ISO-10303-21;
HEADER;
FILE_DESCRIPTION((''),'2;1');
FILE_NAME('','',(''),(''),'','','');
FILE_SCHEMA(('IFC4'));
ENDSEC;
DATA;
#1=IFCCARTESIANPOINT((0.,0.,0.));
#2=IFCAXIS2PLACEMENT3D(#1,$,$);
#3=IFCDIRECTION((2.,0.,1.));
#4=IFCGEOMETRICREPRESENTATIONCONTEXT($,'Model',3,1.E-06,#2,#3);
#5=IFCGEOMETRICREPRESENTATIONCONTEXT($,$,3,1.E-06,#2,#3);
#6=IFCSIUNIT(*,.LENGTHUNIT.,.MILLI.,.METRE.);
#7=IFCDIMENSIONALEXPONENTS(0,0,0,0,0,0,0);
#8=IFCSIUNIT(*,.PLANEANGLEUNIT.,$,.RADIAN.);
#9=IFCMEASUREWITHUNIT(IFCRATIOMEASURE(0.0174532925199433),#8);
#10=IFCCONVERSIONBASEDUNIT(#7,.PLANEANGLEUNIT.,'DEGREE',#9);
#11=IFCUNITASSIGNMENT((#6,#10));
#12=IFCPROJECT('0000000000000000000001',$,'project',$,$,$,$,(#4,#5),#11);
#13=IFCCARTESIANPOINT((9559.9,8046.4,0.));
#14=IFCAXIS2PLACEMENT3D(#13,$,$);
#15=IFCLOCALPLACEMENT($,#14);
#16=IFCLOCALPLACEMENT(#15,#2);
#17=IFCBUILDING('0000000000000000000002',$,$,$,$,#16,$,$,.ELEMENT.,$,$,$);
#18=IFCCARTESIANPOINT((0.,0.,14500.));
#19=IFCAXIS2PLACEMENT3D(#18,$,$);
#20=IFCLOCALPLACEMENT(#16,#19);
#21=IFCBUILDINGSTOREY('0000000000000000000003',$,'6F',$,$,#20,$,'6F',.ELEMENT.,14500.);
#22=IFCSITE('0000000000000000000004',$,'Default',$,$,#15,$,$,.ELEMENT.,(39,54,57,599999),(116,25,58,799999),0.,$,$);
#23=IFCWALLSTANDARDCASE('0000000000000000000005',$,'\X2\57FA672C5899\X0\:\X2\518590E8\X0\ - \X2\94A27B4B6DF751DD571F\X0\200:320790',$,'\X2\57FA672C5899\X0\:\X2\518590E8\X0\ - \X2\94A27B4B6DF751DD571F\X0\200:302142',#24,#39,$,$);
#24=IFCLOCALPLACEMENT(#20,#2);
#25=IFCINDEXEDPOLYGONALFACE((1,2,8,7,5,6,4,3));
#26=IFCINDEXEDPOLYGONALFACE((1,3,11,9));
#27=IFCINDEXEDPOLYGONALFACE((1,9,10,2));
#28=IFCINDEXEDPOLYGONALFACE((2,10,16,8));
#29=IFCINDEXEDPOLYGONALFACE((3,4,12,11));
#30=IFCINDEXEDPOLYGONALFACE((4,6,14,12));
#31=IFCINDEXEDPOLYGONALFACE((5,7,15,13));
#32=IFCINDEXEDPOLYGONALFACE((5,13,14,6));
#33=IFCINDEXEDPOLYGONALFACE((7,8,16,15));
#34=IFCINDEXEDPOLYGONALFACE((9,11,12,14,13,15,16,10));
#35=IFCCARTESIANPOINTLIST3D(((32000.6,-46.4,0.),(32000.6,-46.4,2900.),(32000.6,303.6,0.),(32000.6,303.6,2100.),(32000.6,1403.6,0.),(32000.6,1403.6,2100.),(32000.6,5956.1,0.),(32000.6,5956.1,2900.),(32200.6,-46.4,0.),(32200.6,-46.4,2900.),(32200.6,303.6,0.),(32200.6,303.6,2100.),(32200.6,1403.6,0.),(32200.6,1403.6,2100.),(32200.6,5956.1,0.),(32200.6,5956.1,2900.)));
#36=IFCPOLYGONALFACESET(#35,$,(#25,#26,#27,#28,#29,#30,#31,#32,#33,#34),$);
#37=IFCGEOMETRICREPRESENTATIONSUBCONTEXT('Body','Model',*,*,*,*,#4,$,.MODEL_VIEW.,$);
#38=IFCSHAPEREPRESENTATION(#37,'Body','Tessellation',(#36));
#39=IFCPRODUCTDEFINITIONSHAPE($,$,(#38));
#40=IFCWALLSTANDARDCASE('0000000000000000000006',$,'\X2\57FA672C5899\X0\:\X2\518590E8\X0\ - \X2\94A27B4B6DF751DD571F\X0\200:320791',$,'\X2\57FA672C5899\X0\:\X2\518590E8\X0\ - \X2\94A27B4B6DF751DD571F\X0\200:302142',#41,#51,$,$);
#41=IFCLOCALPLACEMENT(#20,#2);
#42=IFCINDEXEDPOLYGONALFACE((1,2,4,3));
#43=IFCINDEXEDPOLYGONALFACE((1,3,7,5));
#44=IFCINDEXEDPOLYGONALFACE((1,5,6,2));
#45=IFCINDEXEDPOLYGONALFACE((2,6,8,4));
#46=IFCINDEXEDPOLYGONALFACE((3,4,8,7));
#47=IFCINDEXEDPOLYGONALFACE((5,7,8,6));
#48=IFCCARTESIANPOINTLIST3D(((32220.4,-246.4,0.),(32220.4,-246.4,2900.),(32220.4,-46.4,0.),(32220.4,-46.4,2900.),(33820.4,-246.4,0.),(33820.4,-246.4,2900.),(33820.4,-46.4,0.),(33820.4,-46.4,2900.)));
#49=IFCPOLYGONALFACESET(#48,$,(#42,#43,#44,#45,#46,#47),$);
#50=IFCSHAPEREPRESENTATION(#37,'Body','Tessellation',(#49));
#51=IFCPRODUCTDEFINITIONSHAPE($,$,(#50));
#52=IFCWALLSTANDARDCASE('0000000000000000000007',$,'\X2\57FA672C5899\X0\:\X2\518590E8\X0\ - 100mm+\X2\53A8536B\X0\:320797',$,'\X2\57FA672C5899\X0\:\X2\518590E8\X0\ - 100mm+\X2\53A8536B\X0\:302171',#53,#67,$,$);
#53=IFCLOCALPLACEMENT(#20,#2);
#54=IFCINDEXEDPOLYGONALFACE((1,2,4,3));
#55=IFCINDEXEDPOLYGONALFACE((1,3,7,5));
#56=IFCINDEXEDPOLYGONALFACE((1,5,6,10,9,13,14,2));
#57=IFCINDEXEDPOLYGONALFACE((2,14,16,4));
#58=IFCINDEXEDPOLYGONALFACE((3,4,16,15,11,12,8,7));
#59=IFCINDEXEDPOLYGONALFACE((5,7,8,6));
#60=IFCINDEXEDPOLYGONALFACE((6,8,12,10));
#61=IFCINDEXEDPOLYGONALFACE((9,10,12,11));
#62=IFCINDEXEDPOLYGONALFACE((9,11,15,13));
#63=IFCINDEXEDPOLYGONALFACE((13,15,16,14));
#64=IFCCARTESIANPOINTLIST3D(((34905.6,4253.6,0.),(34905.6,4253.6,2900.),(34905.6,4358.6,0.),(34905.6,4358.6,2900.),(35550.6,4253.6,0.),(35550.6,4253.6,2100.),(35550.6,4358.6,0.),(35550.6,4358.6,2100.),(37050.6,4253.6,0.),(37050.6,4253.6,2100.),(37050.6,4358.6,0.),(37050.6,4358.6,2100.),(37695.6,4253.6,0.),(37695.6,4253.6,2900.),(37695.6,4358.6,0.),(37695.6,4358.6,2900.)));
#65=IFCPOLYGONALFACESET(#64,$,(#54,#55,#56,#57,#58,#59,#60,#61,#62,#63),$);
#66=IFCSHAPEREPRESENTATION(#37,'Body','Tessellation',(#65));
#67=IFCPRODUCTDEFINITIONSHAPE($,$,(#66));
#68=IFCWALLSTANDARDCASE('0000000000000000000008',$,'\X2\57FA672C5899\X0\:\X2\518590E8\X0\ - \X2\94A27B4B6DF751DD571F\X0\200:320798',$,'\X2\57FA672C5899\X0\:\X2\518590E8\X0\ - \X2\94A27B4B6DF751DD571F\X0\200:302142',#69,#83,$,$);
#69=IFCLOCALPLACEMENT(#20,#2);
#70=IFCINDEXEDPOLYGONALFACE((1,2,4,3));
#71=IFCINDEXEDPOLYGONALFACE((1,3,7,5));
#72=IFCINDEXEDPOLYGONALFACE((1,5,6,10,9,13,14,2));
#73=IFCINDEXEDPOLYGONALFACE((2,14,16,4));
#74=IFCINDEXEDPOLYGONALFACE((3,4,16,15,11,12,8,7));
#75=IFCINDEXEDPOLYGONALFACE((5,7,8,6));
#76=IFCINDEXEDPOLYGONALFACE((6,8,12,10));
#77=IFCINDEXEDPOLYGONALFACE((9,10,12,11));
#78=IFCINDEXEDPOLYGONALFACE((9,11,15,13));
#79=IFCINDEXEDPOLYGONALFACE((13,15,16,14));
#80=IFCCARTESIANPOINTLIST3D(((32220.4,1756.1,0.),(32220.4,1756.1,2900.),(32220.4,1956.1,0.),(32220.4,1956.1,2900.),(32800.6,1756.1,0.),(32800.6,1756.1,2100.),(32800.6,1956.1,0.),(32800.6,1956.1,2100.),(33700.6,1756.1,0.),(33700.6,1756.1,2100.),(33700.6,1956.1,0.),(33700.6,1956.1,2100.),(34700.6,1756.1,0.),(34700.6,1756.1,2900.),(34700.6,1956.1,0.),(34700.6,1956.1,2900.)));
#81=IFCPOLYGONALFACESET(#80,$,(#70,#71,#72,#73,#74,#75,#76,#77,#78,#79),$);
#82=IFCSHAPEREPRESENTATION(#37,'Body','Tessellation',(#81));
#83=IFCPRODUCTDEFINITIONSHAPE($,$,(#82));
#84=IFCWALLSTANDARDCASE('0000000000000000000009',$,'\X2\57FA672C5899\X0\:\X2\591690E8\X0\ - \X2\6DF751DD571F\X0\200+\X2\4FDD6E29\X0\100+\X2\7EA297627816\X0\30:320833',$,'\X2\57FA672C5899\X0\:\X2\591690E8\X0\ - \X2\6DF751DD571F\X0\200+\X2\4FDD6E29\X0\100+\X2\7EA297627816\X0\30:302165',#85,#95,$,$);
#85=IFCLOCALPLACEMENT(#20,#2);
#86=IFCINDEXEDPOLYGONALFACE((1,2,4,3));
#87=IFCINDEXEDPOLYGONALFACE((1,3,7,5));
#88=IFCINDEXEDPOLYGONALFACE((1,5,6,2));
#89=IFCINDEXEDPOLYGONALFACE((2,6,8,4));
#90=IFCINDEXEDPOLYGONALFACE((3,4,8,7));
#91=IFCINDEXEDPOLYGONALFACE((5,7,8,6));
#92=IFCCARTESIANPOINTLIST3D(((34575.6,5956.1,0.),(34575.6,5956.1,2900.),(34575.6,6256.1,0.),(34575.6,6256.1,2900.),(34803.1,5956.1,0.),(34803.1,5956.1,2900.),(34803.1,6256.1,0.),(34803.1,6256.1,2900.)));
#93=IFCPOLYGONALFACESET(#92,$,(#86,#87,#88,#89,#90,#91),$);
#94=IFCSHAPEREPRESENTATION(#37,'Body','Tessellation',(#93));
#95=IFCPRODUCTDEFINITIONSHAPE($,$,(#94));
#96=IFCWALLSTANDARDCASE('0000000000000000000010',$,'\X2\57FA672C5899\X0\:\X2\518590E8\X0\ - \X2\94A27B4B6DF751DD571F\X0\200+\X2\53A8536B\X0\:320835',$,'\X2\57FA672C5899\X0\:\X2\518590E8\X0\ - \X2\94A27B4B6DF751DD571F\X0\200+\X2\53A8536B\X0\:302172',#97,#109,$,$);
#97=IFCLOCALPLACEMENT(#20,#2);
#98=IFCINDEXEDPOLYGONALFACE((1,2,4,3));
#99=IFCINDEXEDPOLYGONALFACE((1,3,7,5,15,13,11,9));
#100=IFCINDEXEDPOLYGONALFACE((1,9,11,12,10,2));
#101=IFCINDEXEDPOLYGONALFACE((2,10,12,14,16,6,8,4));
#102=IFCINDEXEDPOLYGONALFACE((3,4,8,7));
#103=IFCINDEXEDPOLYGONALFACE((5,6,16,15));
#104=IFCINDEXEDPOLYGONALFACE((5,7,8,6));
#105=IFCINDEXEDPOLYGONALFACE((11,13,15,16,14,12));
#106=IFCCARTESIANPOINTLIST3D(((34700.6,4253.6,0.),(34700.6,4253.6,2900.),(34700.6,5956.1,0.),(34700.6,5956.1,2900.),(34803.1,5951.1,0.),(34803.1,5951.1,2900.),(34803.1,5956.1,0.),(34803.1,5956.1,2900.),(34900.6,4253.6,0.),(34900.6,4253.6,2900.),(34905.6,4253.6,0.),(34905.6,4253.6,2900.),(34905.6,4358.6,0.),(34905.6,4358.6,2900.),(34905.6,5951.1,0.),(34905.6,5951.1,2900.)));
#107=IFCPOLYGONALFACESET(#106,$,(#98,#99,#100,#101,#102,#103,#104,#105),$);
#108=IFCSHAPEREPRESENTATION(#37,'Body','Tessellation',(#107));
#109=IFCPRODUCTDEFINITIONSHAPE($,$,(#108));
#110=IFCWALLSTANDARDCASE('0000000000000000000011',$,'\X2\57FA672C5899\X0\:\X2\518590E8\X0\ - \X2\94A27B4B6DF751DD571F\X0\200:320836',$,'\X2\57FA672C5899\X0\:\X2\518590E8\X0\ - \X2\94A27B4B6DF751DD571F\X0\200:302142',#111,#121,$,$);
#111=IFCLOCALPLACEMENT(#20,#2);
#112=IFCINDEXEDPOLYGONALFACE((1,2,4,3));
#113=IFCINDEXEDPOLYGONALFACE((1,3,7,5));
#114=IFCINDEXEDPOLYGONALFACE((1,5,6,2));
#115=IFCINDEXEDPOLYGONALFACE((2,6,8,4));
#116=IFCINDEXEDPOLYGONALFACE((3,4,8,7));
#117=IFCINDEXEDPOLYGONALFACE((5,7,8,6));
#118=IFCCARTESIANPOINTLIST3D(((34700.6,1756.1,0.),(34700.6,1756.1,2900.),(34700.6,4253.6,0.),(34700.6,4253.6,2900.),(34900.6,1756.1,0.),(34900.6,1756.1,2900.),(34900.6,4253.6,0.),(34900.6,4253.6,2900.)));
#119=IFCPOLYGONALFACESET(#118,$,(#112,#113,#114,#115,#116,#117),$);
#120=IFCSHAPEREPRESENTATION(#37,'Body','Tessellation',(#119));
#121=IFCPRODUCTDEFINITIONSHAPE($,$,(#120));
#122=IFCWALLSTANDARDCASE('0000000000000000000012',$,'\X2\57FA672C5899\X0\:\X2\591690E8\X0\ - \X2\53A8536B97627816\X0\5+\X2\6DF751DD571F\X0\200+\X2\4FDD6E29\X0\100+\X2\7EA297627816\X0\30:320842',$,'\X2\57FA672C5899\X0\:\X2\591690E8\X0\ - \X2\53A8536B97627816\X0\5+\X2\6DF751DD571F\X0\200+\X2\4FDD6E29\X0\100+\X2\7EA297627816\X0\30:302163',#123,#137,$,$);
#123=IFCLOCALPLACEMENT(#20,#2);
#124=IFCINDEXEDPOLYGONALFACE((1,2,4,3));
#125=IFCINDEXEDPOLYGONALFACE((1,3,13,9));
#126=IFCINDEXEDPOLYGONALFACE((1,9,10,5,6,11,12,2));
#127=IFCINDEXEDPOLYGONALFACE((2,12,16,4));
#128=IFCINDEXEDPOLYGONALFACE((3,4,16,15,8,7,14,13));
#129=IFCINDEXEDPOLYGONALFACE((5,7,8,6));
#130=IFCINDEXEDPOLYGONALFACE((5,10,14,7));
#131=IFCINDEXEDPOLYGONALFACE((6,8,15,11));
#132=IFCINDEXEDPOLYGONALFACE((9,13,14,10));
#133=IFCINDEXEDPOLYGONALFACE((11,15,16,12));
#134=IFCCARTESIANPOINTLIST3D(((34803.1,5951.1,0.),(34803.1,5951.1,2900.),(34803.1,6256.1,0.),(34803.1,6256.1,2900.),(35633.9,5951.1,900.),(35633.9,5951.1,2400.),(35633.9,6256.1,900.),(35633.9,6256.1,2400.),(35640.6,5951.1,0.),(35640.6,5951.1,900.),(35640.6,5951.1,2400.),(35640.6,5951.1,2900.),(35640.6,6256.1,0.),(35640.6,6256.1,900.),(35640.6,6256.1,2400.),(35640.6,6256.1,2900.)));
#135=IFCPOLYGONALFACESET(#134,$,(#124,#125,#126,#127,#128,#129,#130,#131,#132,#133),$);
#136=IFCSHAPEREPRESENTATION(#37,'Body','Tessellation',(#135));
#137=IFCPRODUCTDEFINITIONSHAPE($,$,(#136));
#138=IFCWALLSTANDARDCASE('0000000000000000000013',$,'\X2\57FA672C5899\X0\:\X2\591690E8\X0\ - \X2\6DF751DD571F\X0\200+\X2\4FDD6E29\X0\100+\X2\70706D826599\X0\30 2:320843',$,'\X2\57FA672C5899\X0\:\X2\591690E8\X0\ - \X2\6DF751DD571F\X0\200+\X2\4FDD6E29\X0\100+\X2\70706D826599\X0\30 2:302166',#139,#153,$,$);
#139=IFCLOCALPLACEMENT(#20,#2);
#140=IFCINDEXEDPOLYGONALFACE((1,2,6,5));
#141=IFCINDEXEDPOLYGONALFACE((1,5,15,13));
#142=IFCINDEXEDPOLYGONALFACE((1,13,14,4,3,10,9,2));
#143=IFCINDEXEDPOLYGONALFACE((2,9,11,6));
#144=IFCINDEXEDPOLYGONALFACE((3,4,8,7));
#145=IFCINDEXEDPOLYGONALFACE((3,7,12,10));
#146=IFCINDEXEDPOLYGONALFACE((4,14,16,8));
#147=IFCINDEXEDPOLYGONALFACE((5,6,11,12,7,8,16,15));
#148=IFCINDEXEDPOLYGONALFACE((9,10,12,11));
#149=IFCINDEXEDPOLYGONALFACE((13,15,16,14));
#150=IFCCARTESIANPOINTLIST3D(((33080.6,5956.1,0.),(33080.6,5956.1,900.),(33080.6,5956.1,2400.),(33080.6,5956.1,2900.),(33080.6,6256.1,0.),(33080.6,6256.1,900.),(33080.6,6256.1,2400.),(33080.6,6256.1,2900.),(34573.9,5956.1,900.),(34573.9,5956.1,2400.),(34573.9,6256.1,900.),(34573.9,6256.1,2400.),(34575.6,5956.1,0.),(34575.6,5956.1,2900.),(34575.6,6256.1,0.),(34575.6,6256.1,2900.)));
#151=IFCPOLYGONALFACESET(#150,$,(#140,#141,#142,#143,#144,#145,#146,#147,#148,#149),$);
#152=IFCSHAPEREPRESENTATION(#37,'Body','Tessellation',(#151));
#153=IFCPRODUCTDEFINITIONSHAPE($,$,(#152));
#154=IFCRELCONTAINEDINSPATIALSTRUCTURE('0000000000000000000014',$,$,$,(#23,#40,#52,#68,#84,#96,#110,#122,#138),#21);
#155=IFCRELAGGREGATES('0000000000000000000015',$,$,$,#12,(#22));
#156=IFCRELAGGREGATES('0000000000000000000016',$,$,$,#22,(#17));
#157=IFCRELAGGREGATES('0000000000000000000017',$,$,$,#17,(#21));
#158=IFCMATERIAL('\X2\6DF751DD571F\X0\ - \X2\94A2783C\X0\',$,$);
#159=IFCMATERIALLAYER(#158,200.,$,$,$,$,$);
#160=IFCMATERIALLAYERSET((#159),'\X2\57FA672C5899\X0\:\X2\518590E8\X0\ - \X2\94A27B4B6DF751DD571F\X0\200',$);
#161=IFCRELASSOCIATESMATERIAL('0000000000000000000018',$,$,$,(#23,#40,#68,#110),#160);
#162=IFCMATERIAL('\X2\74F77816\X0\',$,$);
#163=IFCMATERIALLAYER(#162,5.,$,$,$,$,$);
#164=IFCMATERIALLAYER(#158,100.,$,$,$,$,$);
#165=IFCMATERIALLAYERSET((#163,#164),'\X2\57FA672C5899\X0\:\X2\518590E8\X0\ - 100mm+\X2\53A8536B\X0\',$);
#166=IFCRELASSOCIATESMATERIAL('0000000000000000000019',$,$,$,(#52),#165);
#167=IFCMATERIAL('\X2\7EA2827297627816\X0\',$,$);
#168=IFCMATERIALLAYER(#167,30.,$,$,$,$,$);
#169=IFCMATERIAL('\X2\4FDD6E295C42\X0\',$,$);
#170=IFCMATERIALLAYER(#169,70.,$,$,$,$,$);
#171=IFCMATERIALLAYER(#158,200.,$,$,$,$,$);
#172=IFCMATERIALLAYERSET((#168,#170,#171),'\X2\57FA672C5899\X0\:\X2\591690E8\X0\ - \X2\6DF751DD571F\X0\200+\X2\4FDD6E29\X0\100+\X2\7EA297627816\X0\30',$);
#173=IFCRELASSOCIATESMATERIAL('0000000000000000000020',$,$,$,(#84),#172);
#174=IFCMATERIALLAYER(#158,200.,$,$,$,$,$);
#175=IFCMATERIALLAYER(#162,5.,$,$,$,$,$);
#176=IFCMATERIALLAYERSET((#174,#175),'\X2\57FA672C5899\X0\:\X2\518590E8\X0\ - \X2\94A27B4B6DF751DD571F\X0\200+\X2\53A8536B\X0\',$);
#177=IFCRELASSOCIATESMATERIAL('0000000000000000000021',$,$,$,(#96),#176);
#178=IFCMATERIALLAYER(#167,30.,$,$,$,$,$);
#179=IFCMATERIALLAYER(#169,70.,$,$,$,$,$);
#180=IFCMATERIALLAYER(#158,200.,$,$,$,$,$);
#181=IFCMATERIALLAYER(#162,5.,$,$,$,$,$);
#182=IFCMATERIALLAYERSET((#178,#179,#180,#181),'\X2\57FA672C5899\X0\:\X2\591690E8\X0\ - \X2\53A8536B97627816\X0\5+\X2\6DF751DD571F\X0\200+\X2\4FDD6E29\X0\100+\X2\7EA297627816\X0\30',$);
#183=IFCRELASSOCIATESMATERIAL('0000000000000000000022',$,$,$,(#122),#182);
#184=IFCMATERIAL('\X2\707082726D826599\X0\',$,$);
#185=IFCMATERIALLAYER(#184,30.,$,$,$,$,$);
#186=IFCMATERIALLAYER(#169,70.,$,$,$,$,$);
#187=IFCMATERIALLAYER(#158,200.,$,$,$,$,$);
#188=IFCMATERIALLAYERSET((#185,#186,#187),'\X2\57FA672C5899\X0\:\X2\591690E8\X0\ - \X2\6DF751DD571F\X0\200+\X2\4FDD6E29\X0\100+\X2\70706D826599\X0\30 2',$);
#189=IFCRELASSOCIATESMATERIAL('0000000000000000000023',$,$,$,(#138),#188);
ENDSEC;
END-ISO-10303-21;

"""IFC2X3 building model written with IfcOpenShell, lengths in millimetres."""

from ifc_helpers import new_model, entity, si_unit, converted_unit, direction, frame, frame_2d, origin, place, context, subcontext, project, spatial, polyline, rectangle, outline, extrude, material, layer, layer_set, layer_usage, element, save


model = new_model("IFC2X3")

# Units and contexts
model_context = context("Model", 3, precision=1e-06, world=origin(), true_north=direction((2.0, 0.0, 1.0)))
context_of_model = context(None, 3, precision=1e-06, world=origin(), true_north=direction((2.0, 0.0, 1.0)))
body_context = subcontext(model_context, "Body", "Model", "MODEL_VIEW")
ifc_project = project(units=[si_unit("LENGTHUNIT", "METRE", prefix="MILLI"), converted_unit("PLANEANGLEUNIT", "DEGREE", entity("IfcRatioMeasure", 0.0174532925199433), si_unit("PLANEANGLEUNIT", "RADIAN"), dimensions=[0, 0, 0, 0, 0, 0, 0])], contexts=[model_context, context_of_model])

# Site, building, storey
site_placement = place(None, frame((9559.9, 8046.4, 0.0)))
site = spatial("IfcSite", under=ifc_project, at=site_placement, Name="Default", CompositionType="ELEMENT", RefLatitude=(39, 54, 57, 599999), RefLongitude=(116, 25, 58, 799999), RefElevation=0.0)
building_placement = place(site_placement, origin())
building = spatial("IfcBuilding", under=site, at=building_placement, CompositionType="ELEMENT")
storey_placement = place(building_placement, frame((0.0, 0.0, 14500.0)))
storey = spatial("IfcBuildingStorey", under=building, at=storey_placement, Name="6F", LongName="6F", CompositionType="ELEMENT", Elevation=14500.0)

# Shared definitions
ifc_material_1 = material(Name="混凝土 - 钢砼")
ifc_layer_1 = layer(ifc_material_1, 200.0)
ifc_material_2 = material(Name="瓷砖")
ifc_layer_2 = layer(ifc_material_2, 5.0)
ifc_layer_set_1 = layer_set([ifc_layer_1, ifc_layer_2], Name="基本墙:内部 - 钢筋混凝土200+厨卫")

# Wall, opening
ifc_layer_3 = layer(ifc_material_1, 200.0)
ifc_layer_set_2 = layer_set([ifc_layer_3], Name="基本墙:内部 - 钢筋混凝土200")
ifc_layer_usage_1 = layer_usage(ifc_layer_set_2, "AXIS2", "POSITIVE", -100.0)
wall_1_placement = place(storey_placement, frame((32100.6, 5956.1, 0.0), z_axis=(0.0, 0.0, 1.0), x_axis=(0.0, -1.0, 0.0)))
wall_1 = element("IfcWallStandardCase", 1, at=wall_1_placement, inside=storey, material=ifc_layer_usage_1, Name="基本墙:内部 - 钢筋混凝土200:320790", ObjectType="基本墙:内部 - 钢筋混凝土200:302142", context=body_context, shape_type="SweptSolid", body=[
    extrude(rectangle(XDim=6002.5, YDim=200.0, at=frame_2d((3001.2, 0.0), x_axis=(-1.0, 0.0))), origin(), (0.0, 0.0, 1.0), 2900.0),
])
opening_1_placement = place(wall_1_placement, frame((5652.5, 100.0, 0.0)))
element("IfcOpeningElement", 2, at=opening_1_placement, cuts=wall_1, ObjectType="Opening", context=body_context, shape_type="SweptSolid", body=[
    extrude(rectangle(XDim=2100.0, YDim=1100.0, at=frame_2d((1050.0, 550.0), x_axis=(1.0, 0.0))), frame((0.0, 0.0, 0.0), z_axis=(0.0, -1.0, 0.0), x_axis=(0.0, 0.0, 1.0)), (0.0, 0.0, 1.0), 200.0),
])

# Wall
ifc_layer_usage_2 = layer_usage(ifc_layer_set_2, "AXIS2", "POSITIVE", -100.0)
wall_2_placement = place(storey_placement, frame((32220.4, -146.4, 0.0)))
element("IfcWallStandardCase", 3, at=wall_2_placement, inside=storey, material=ifc_layer_usage_2, Name="基本墙:内部 - 钢筋混凝土200:320791", ObjectType="基本墙:内部 - 钢筋混凝土200:302142", context=body_context, shape_type="SweptSolid", body=[
    extrude(rectangle(XDim=1600.0, YDim=200.0, at=frame_2d((800.0, 0.0), x_axis=(-1.0, 0.0))), origin(), (0.0, 0.0, 1.0), 2900.0),
])

# Walls, openings
ifc_layer_4 = layer(ifc_material_2, 5.0)
ifc_layer_5 = layer(ifc_material_1, 100.0)
ifc_layer_set_3 = layer_set([ifc_layer_4, ifc_layer_5], Name="基本墙:内部 - 100mm+厨卫")
ifc_layer_usage_3 = layer_usage(ifc_layer_set_3, "AXIS2", "POSITIVE", -52.5)
wall_3_placement = place(storey_placement, frame((37695.6, 4306.1, 0.0), z_axis=(0.0, 0.0, 1.0), x_axis=(-1.0, 0.0, 0.0)))
wall_3 = element("IfcWallStandardCase", 4, at=wall_3_placement, inside=storey, material=ifc_layer_usage_3, Name="基本墙:内部 - 100mm+厨卫:320797", ObjectType="基本墙:内部 - 100mm+厨卫:302171", context=body_context, shape_type="SweptSolid", body=[
    extrude(rectangle(XDim=2790.0, YDim=105.0, at=frame_2d((1395.0, 0.0), x_axis=(-1.0, 0.0))), origin(), (0.0, 0.0, 1.0), 2900.0),
])
opening_2_placement = place(wall_3_placement, frame((645.0, -52.5, 0.0)))
element("IfcOpeningElement", 5, at=opening_2_placement, cuts=wall_3, ObjectType="Opening", context=body_context, shape_type="SweptSolid", body=[
    extrude(rectangle(XDim=2100.0, YDim=1500.0, at=frame_2d((1050.0, 750.0), x_axis=(1.0, 0.0))), frame((0.0, 0.0, 0.0), z_axis=(0.0, 1.0, 0.0), x_axis=(0.0, 0.0, 1.0)), (0.0, 0.0, 1.0), 105.0),
])
ifc_layer_usage_4 = layer_usage(ifc_layer_set_2, "AXIS2", "POSITIVE", -100.0)
wall_4_placement = place(storey_placement, frame((34700.6, 1856.1, 0.0), z_axis=(0.0, 0.0, 1.0), x_axis=(-1.0, 0.0, 0.0)))
wall_4 = element("IfcWallStandardCase", 6, at=wall_4_placement, inside=storey, material=ifc_layer_usage_4, Name="基本墙:内部 - 钢筋混凝土200:320798", ObjectType="基本墙:内部 - 钢筋混凝土200:302142", context=body_context, shape_type="SweptSolid", body=[
    extrude(rectangle(XDim=2480.2, YDim=200.0, at=frame_2d((1240.1, 0.0), x_axis=(-1.0, 0.0))), origin(), (0.0, 0.0, 1.0), 2900.0),
])
opening_3_placement = place(wall_4_placement, frame((1900.0, 100.0, 0.0)))
element("IfcOpeningElement", 7, at=opening_3_placement, cuts=wall_4, ObjectType="Opening", context=body_context, shape_type="SweptSolid", body=[
    extrude(rectangle(XDim=2100.0, YDim=900.0, at=frame_2d((1050.0, 450.0), x_axis=(1.0, 0.0))), frame((0.0, 0.0, 0.0), z_axis=(0.0, -1.0, 0.0), x_axis=(0.0, 0.0, 1.0)), (0.0, 0.0, 1.0), 200.0),
])

# Walls
ifc_material_3 = material(Name="红色面砖")
ifc_layer_6 = layer(ifc_material_3, 30.0)
ifc_material_4 = material(Name="保温层")
ifc_layer_7 = layer(ifc_material_4, 70.0)
ifc_layer_8 = layer(ifc_material_1, 200.0)
ifc_layer_set_4 = layer_set([ifc_layer_6, ifc_layer_7, ifc_layer_8], Name="基本墙:外部 - 混凝土200+保温100+红面砖30")
ifc_layer_usage_5 = layer_usage(ifc_layer_set_4, "AXIS2", "POSITIVE", -150.0)
wall_5_placement = place(storey_placement, frame((34803.1, 6106.1, 0.0), z_axis=(0.0, 0.0, 1.0), x_axis=(-1.0, 0.0, 0.0)))
element("IfcWallStandardCase", 8, at=wall_5_placement, inside=storey, material=ifc_layer_usage_5, Name="基本墙:外部 - 混凝土200+保温100+红面砖30:320833", ObjectType="基本墙:外部 - 混凝土200+保温100+红面砖30:302165", context=body_context, shape_type="SweptSolid", body=[
    extrude(rectangle(XDim=227.5, YDim=300.0, at=frame_2d((113.8, 0.0), x_axis=(-1.0, 0.0))), origin(), (0.0, 0.0, 1.0), 2900.0),
])
ifc_layer_usage_6 = layer_usage(ifc_layer_set_1, "AXIS2", "POSITIVE", -102.5)
wall_6_placement = place(storey_placement, frame((34803.1, 5956.1, 0.0), z_axis=(0.0, 0.0, 1.0), x_axis=(0.0, -1.0, 0.0)))
element("IfcWallStandardCase", 9, at=wall_6_placement, inside=storey, material=ifc_layer_usage_6, Name="基本墙:内部 - 钢筋混凝土200+厨卫:320835", ObjectType="基本墙:内部 - 钢筋混凝土200+厨卫:302172", context=body_context, shape_type="SweptSolid", body=[
    extrude(outline(polyline([(1702.5, -102.5), (1702.5, 97.5), (1702.5, 102.5), (1597.5, 102.5), (5.0, 102.5), (5.0, 0.0), (0.0, 0.0), (0.0, -102.5), (1702.5, -102.5)])), origin(), (0.0, 0.0, 1.0), 2900.0),
])
ifc_layer_usage_7 = layer_usage(ifc_layer_set_2, "AXIS2", "POSITIVE", -100.0)
wall_7_placement = place(storey_placement, frame((34800.6, 4253.6, 0.0), z_axis=(0.0, 0.0, 1.0), x_axis=(0.0, -1.0, 0.0)))
element("IfcWallStandardCase", 10, at=wall_7_placement, inside=storey, material=ifc_layer_usage_7, Name="基本墙:内部 - 钢筋混凝土200:320836", ObjectType="基本墙:内部 - 钢筋混凝土200:302142", context=body_context, shape_type="SweptSolid", body=[
    extrude(rectangle(XDim=2497.5, YDim=200.0, at=frame_2d((1248.8, 0.0), x_axis=(-1.0, 0.0))), origin(), (0.0, 0.0, 1.0), 2900.0),
])

# Walls, openings
ifc_layer_9 = layer(ifc_material_3, 30.0)
ifc_layer_10 = layer(ifc_material_4, 70.0)
ifc_layer_11 = layer(ifc_material_1, 200.0)
ifc_layer_12 = layer(ifc_material_2, 5.0)
ifc_layer_set_5 = layer_set([ifc_layer_9, ifc_layer_10, ifc_layer_11, ifc_layer_12], Name="基本墙:外部 - 厨卫面砖5+混凝土200+保温100+红面砖30")
ifc_layer_usage_8 = layer_usage(ifc_layer_set_5, "AXIS2", "POSITIVE", -152.5)
wall_8_placement = place(storey_placement, frame((35640.6, 6103.6, 0.0), z_axis=(0.0, 0.0, 1.0), x_axis=(-1.0, 0.0, 0.0)))
wall_8 = element("IfcWallStandardCase", 11, at=wall_8_placement, inside=storey, material=ifc_layer_usage_8, Name="基本墙:外部 - 厨卫面砖5+混凝土200+保温100+红面砖30:320842", ObjectType="基本墙:外部 - 厨卫面砖5+混凝土200+保温100+红面砖30:302163", context=body_context, shape_type="SweptSolid", body=[
    extrude(rectangle(XDim=837.5, YDim=305.0, at=frame_2d((418.8, 0.0), x_axis=(-1.0, 0.0))), origin(), (0.0, 0.0, 1.0), 2900.0),
])
opening_4_placement = place(wall_8_placement, frame((6.7, 152.5, 900.0)))
element("IfcOpeningElement", 12, at=opening_4_placement, cuts=wall_8, ObjectType="Opening", context=body_context, shape_type="SweptSolid", body=[
    extrude(rectangle(XDim=1500.0, YDim=1800.0, at=frame_2d((750.0, 900.0), x_axis=(1.0, 0.0))), frame((0.0, 0.0, 0.0), z_axis=(0.0, -1.0, 0.0), x_axis=(0.0, 0.0, 1.0)), (0.0, 0.0, 1.0), 305.0),
])
ifc_material_5 = material(Name="灰色涂料")
ifc_layer_13 = layer(ifc_material_5, 30.0)
ifc_layer_14 = layer(ifc_material_4, 70.0)
ifc_layer_15 = layer(ifc_material_1, 200.0)
ifc_layer_set_6 = layer_set([ifc_layer_13, ifc_layer_14, ifc_layer_15], Name="基本墙:外部 - 混凝土200+保温100+灰涂料30 2")
ifc_layer_usage_9 = layer_usage(ifc_layer_set_6, "AXIS2", "POSITIVE", -150.0)
wall_9_placement = place(storey_placement, frame((34575.6, 6106.1, 0.0), z_axis=(0.0, 0.0, 1.0), x_axis=(-1.0, 0.0, 0.0)))
wall_9 = element("IfcWallStandardCase", 13, at=wall_9_placement, inside=storey, material=ifc_layer_usage_9, Name="基本墙:外部 - 混凝土200+保温100+灰涂料30 2:320843", ObjectType="基本墙:外部 - 混凝土200+保温100+灰涂料30 2:302166", context=body_context, shape_type="SweptSolid", body=[
    extrude(rectangle(XDim=1495.0, YDim=300.0, at=frame_2d((747.5, 0.0), x_axis=(-1.0, 0.0))), origin(), (0.0, 0.0, 1.0), 2900.0),
])
opening_5_placement = place(wall_9_placement, frame((1501.7, 150.0, 900.0)))
element("IfcOpeningElement", 14, at=opening_5_placement, cuts=wall_9, ObjectType="Opening", context=body_context, shape_type="SweptSolid", body=[
    extrude(rectangle(XDim=1500.0, YDim=1500.0, at=frame_2d((750.0, 750.0), x_axis=(1.0, 0.0))), frame((0.0, 0.0, 0.0), z_axis=(0.0, -1.0, 0.0), x_axis=(0.0, 0.0, 1.0)), (0.0, 0.0, 1.0), 300.0),
])

save(model, "model.ifc")
